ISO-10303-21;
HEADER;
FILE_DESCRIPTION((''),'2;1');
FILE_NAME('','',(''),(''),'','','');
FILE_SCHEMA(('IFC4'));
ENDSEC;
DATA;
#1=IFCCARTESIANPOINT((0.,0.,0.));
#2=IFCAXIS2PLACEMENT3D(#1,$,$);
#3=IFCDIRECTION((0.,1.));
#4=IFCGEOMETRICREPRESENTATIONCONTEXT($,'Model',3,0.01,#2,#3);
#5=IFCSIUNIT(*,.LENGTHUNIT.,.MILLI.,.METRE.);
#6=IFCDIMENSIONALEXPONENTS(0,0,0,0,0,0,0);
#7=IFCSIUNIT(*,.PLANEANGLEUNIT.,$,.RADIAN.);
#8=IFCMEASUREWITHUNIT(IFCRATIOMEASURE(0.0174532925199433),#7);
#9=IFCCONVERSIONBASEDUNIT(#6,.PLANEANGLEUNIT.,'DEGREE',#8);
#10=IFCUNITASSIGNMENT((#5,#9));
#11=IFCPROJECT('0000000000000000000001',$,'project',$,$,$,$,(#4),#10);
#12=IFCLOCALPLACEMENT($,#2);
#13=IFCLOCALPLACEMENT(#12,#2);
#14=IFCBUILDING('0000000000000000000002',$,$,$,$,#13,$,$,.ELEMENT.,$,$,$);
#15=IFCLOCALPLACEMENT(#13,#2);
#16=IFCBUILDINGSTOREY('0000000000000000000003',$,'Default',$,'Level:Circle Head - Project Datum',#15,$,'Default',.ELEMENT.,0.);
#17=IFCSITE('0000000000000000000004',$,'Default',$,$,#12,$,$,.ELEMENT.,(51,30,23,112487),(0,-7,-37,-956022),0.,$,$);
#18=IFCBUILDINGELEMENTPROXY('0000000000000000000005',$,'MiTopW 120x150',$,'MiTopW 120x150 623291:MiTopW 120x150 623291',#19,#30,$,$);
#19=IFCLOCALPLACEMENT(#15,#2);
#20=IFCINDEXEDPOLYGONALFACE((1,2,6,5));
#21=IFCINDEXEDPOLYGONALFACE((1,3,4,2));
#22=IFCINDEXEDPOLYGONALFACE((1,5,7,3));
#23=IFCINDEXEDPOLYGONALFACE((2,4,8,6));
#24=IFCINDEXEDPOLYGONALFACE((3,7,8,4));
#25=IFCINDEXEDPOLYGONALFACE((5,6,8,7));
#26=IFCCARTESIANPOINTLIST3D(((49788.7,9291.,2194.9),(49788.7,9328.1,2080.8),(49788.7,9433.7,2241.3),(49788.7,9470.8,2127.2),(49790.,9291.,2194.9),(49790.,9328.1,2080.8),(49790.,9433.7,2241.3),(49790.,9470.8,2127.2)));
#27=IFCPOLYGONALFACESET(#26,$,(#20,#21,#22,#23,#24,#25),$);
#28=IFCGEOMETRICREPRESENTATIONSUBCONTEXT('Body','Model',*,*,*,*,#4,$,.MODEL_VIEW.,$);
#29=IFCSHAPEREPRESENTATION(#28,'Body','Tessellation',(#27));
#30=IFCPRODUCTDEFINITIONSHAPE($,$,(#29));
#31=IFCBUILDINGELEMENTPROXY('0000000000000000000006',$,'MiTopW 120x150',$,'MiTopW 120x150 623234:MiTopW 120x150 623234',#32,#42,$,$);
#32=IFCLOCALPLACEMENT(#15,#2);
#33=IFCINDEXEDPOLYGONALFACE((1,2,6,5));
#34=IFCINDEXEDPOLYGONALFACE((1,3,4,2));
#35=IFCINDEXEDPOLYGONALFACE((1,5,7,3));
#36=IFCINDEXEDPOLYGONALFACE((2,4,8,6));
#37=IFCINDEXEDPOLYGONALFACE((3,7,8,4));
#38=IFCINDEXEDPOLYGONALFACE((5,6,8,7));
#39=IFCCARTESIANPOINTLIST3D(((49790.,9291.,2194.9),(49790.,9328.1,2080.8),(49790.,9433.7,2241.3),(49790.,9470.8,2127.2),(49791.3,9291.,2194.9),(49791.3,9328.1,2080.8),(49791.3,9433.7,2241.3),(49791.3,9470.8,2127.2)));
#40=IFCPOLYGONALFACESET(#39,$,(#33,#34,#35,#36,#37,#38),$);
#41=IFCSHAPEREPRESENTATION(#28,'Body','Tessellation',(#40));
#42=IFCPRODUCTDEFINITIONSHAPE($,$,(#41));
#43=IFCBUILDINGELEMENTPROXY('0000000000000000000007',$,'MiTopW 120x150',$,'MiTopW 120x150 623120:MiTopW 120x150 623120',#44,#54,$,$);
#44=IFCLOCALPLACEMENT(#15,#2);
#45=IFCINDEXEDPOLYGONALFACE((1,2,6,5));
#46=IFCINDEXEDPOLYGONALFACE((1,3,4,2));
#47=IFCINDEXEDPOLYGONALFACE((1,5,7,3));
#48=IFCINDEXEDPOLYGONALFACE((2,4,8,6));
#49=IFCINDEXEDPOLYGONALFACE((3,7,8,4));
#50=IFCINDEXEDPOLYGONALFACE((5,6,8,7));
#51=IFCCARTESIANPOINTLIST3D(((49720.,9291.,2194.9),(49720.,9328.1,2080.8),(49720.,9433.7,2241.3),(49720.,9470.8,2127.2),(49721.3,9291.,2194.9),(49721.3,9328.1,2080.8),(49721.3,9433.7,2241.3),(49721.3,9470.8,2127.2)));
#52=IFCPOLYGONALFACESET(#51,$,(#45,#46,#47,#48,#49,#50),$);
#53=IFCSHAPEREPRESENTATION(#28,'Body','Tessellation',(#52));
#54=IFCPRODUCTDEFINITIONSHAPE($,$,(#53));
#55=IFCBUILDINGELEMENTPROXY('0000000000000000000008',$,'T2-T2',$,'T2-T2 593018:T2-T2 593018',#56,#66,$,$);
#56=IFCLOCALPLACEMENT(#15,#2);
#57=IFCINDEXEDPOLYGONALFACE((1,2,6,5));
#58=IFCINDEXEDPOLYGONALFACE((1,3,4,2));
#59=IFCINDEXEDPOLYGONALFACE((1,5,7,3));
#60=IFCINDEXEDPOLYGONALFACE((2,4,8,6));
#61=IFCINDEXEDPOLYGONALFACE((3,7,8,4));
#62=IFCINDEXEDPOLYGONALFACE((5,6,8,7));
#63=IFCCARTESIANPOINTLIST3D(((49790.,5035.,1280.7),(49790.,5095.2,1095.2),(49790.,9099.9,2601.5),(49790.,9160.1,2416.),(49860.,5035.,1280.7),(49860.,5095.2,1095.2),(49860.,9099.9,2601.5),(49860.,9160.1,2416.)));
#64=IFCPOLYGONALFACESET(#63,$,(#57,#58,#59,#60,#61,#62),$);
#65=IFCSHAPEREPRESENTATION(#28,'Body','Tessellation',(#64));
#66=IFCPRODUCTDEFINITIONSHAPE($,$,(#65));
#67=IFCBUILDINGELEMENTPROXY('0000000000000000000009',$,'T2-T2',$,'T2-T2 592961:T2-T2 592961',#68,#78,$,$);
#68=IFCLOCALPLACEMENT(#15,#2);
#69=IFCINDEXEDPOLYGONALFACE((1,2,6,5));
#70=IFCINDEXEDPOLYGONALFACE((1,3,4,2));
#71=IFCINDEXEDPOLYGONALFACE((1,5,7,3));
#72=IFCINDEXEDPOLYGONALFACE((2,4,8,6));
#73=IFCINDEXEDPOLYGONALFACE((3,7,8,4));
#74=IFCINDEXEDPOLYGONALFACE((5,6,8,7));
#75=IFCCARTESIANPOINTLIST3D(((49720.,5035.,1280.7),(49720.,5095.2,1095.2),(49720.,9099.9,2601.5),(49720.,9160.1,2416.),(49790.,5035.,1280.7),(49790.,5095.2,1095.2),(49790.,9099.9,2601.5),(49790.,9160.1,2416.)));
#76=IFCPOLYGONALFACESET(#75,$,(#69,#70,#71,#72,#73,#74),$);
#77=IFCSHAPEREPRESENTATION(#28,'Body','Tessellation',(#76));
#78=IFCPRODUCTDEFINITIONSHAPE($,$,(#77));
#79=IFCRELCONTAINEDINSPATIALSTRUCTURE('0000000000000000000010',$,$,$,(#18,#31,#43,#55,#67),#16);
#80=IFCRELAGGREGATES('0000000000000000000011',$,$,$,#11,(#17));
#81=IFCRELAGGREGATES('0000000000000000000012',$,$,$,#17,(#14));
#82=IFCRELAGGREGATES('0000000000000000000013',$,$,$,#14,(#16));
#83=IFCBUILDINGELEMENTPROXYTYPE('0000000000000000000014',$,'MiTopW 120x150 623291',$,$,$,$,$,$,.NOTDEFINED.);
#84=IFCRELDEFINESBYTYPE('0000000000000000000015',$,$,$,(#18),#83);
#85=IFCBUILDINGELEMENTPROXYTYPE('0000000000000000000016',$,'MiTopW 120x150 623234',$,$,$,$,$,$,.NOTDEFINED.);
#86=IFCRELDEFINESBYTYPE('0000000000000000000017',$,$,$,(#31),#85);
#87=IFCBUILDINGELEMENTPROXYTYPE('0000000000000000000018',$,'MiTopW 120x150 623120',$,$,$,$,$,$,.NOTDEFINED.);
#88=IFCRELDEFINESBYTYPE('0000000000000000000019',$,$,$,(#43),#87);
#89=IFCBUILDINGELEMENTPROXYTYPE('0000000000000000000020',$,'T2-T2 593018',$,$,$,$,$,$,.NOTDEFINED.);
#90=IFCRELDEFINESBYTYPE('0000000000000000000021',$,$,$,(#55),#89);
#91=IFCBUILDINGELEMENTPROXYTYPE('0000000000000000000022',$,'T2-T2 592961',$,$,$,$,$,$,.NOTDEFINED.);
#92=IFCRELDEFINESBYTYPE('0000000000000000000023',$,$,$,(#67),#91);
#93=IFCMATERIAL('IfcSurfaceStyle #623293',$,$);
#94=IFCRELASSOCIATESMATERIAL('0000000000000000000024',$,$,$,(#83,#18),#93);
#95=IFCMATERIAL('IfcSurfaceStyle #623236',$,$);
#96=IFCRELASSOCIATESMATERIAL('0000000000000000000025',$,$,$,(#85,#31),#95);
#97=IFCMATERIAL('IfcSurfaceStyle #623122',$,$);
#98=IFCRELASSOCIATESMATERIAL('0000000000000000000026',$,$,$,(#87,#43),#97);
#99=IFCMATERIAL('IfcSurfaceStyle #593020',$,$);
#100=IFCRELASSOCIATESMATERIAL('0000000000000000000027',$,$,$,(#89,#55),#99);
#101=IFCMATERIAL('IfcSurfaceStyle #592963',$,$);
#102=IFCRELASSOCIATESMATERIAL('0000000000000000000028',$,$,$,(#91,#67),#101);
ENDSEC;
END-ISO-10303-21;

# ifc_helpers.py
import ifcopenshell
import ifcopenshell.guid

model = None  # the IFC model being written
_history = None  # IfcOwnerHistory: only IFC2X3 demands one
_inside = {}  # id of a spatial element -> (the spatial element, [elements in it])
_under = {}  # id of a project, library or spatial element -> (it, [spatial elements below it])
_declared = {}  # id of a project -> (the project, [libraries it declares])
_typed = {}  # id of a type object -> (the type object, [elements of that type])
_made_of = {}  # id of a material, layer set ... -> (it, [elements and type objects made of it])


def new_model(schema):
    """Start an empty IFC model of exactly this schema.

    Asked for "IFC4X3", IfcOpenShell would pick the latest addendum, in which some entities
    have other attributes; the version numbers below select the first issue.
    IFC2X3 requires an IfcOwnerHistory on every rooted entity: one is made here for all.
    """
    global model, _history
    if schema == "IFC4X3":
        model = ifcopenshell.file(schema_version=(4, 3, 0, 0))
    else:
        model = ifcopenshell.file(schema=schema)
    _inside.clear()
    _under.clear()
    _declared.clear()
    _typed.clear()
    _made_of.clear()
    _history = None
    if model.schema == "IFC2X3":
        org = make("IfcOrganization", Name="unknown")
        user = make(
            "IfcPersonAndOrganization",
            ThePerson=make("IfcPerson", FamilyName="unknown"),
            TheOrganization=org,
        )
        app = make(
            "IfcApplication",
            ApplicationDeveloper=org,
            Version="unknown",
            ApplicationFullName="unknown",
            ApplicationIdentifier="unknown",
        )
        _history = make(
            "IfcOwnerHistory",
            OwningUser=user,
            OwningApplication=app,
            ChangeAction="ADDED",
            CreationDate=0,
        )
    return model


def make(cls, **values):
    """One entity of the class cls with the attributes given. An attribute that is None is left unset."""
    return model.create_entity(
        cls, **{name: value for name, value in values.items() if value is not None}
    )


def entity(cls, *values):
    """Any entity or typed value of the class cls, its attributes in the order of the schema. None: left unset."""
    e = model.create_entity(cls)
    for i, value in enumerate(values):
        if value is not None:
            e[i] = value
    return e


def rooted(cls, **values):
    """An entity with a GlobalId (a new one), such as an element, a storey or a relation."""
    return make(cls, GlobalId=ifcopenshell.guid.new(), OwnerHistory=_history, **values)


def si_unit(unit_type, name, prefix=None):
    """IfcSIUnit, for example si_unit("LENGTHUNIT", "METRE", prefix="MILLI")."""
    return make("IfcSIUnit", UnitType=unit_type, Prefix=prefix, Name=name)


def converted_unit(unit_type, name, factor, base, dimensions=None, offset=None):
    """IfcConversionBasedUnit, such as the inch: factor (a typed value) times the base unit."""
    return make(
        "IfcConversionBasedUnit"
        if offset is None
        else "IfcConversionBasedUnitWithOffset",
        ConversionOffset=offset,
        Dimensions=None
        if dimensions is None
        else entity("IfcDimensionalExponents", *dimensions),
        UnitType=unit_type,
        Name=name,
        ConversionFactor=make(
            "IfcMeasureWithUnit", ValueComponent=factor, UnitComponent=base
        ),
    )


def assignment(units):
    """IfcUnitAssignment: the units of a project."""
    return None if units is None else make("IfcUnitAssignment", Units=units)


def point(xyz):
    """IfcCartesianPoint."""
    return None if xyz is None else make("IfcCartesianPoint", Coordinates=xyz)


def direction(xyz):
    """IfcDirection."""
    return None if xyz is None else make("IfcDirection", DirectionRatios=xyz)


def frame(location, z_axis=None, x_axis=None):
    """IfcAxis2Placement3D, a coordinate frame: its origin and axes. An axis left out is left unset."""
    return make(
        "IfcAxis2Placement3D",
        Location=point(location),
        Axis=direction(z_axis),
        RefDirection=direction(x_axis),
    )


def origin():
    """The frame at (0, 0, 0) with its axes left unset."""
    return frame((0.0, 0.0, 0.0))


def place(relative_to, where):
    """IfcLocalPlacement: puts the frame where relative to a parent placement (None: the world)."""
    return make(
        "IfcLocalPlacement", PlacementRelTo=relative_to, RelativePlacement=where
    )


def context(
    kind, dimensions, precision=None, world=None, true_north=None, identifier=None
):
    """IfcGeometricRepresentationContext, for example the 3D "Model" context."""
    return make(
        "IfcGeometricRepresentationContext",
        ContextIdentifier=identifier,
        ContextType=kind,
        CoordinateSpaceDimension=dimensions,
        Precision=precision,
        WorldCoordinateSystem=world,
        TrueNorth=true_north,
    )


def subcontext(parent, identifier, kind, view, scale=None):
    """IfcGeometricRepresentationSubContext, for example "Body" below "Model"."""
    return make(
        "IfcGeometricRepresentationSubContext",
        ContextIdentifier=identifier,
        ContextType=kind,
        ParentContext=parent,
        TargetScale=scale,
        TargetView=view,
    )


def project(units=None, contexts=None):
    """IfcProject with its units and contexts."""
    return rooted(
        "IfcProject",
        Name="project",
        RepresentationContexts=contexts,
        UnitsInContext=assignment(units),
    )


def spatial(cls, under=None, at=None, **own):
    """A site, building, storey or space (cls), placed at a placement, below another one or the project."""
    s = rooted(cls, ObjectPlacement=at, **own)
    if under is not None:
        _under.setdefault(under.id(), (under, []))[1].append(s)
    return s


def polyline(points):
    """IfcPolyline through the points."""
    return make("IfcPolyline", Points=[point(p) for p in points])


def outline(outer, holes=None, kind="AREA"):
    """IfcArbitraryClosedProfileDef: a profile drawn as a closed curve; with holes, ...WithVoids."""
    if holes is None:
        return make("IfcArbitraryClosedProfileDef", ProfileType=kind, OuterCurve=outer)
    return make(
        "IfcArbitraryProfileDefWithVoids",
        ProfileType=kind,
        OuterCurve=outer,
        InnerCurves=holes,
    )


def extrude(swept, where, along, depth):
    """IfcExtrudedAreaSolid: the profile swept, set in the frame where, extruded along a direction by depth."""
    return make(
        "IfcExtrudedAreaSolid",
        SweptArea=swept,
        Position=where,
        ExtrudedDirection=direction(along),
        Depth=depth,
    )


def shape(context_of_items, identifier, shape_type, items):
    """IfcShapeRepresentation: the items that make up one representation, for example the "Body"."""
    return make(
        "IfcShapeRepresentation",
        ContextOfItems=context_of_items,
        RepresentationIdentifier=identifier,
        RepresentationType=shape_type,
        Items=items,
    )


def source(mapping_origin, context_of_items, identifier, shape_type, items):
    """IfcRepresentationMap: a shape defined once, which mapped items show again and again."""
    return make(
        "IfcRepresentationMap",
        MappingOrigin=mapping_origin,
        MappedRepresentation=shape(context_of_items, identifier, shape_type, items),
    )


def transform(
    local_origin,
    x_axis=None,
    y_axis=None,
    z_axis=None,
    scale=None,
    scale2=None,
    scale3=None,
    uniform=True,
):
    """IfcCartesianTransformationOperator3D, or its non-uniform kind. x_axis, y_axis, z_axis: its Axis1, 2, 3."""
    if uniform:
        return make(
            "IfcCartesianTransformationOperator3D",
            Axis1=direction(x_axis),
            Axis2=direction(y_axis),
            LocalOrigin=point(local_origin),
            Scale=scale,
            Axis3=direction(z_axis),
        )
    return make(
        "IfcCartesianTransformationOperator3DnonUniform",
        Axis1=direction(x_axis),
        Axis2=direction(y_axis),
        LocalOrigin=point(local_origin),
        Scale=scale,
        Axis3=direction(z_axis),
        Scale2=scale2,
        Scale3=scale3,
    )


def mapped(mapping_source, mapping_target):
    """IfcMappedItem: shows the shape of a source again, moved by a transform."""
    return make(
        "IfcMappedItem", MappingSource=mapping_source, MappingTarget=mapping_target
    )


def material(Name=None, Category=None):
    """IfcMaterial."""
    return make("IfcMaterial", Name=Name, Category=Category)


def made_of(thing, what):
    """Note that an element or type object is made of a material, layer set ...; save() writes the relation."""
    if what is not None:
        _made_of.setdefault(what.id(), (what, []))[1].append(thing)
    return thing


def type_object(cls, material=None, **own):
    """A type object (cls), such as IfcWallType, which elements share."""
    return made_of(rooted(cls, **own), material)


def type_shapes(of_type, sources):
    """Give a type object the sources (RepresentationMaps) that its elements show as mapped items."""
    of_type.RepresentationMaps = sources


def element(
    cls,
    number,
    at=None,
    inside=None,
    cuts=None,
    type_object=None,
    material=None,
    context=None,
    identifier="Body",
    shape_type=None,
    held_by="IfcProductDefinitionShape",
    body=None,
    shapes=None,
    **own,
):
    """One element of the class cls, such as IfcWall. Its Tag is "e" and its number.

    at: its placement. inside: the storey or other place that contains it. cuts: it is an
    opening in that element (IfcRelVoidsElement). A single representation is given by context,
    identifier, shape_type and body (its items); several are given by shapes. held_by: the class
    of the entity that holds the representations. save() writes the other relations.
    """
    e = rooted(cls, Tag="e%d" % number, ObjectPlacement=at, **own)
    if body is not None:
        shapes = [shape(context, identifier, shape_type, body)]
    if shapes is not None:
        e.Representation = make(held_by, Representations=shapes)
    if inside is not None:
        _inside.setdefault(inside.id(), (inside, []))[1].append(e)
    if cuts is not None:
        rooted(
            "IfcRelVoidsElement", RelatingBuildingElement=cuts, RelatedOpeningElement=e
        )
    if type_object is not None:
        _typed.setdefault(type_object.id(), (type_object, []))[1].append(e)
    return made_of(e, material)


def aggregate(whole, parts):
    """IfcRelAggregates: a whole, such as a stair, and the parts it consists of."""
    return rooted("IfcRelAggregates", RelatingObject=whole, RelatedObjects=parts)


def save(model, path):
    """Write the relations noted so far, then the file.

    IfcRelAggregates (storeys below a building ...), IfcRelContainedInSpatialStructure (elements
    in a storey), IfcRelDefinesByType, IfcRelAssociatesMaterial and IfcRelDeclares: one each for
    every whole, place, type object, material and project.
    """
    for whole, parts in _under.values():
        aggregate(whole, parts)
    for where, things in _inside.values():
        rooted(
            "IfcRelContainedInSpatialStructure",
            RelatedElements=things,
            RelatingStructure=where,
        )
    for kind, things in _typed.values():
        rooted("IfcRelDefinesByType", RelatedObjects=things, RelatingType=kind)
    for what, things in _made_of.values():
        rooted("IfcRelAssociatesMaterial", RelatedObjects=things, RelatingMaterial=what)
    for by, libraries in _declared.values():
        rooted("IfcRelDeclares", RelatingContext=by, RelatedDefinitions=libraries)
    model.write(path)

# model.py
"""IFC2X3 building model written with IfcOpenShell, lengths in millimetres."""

from ifc_helpers import new_model, entity, si_unit, converted_unit, direction, frame, origin, place, context, subcontext, project, spatial, polyline, outline, extrude, source, transform, mapped, material, type_object, type_shapes, element, save


model = new_model("IFC2X3")

# Units and contexts
model_context = context("Model", 3, precision=0.01, world=origin(), true_north=direction((0.0, 1.0)))
body_context = subcontext(model_context, "Body", "Model", "MODEL_VIEW")
ifc_project = project(units=[si_unit("LENGTHUNIT", "METRE", prefix="MILLI"), converted_unit("PLANEANGLEUNIT", "DEGREE", entity("IfcRatioMeasure", 0.0174532925199433), si_unit("PLANEANGLEUNIT", "RADIAN"), dimensions=[0, 0, 0, 0, 0, 0, 0])], contexts=[model_context])

# Site, building, storey
site_placement = place(None, origin())
site = spatial("IfcSite", under=ifc_project, at=site_placement, Name="Default", CompositionType="ELEMENT", RefLatitude=(51, 30, 23, 112487), RefLongitude=(0, -7, -37, -956022), RefElevation=0.0)
building_placement = place(site_placement, origin())
building = spatial("IfcBuilding", under=site, at=building_placement, CompositionType="ELEMENT")
storey_placement = place(building_placement, origin())
storey = spatial("IfcBuildingStorey", under=building, at=storey_placement, Name="Default", ObjectType="Level:Circle Head - Project Datum", LongName="Default", CompositionType="ELEMENT", Elevation=0.0)

# Building element proxies
ifc_material_1 = material(Name="IfcSurfaceStyle #623293")
building_element_proxy_type_1 = type_object("IfcBuildingElementProxyType", Name="MiTopW 120x150 623291", PredefinedType="NOTDEFINED", material=ifc_material_1)
shared_shape_1 = source(origin(), body_context, "Body", "SweptSolid", [
    extrude(outline(polyline([(-75.0, -60.0), (75.0, -60.0), (75.0, 60.0), (-75.0, 60.0), (-75.0, -60.0)])), frame((75.0, 60.0, 0.0), z_axis=(0.0, 0.0, 1.0), x_axis=(-1.0, 0.0, 0.0)), (0.0, 0.0, 1.0), 1.3),
])
type_shapes(building_element_proxy_type_1, [shared_shape_1])
proxy_1_placement = place(building_placement, frame((49790.0, 9291.0, 2194.9), z_axis=(-1.0, 0.0, 0.0), x_axis=(0.0, 0.951057, 0.309017)))
element("IfcBuildingElementProxy", 1, at=proxy_1_placement, inside=storey, type_object=building_element_proxy_type_1, material=ifc_material_1, Name="MiTopW 120x150", ObjectType="MiTopW 120x150 623291:MiTopW 120x150 623291", context=body_context, shape_type="MappedRepresentation", body=[
    mapped(shared_shape_1, transform((0.0, 0.0, 0.0), scale=1.0)),
])
ifc_material_2 = material(Name="IfcSurfaceStyle #623236")
building_element_proxy_type_2 = type_object("IfcBuildingElementProxyType", Name="MiTopW 120x150 623234", PredefinedType="NOTDEFINED", material=ifc_material_2)
shared_shape_2 = source(origin(), body_context, "Body", "SweptSolid", [
    extrude(outline(polyline([(-75.0, -60.0), (75.0, -60.0), (75.0, 60.0), (-75.0, 60.0), (-75.0, -60.0)])), frame((75.0, 60.0, 0.0), z_axis=(0.0, 0.0, 1.0), x_axis=(-1.0, 0.0, 0.0)), (0.0, 0.0, 1.0), 1.3),
])
type_shapes(building_element_proxy_type_2, [shared_shape_2])
proxy_2_placement = place(building_placement, frame((49791.3, 9291.0, 2194.9), z_axis=(-1.0, 0.0, 0.0), x_axis=(0.0, 0.951057, 0.309017)))
element("IfcBuildingElementProxy", 2, at=proxy_2_placement, inside=storey, type_object=building_element_proxy_type_2, material=ifc_material_2, Name="MiTopW 120x150", ObjectType="MiTopW 120x150 623234:MiTopW 120x150 623234", context=body_context, shape_type="MappedRepresentation", body=[
    mapped(shared_shape_2, transform((0.0, 0.0, 0.0), scale=1.0)),
])
ifc_material_3 = material(Name="IfcSurfaceStyle #623122")
building_element_proxy_type_3 = type_object("IfcBuildingElementProxyType", Name="MiTopW 120x150 623120", PredefinedType="NOTDEFINED", material=ifc_material_3)
shared_shape_3 = source(origin(), body_context, "Body", "SweptSolid", [
    extrude(outline(polyline([(-75.0, -60.0), (75.0, -60.0), (75.0, 60.0), (-75.0, 60.0), (-75.0, -60.0)])), frame((75.0, 60.0, 0.0), z_axis=(0.0, 0.0, 1.0), x_axis=(-1.0, 0.0, 0.0)), (0.0, 0.0, 1.0), 1.3),
])
type_shapes(building_element_proxy_type_3, [shared_shape_3])
proxy_3_placement = place(building_placement, frame((49721.3, 9291.0, 2194.9), z_axis=(-1.0, 0.0, 0.0), x_axis=(0.0, 0.951057, 0.309017)))
element("IfcBuildingElementProxy", 3, at=proxy_3_placement, inside=storey, type_object=building_element_proxy_type_3, material=ifc_material_3, Name="MiTopW 120x150", ObjectType="MiTopW 120x150 623120:MiTopW 120x150 623120", context=body_context, shape_type="MappedRepresentation", body=[
    mapped(shared_shape_3, transform((0.0, 0.0, 0.0), scale=1.0)),
])
ifc_material_4 = material(Name="IfcSurfaceStyle #593020")
building_element_proxy_type_4 = type_object("IfcBuildingElementProxyType", Name="T2-T2 593018", PredefinedType="NOTDEFINED", material=ifc_material_4)
shared_shape_4 = source(origin(), body_context, "Body", "SweptSolid", [
    extrude(outline(polyline([(-2137.0, -97.5), (2137.0, -97.5), (2137.0, 97.5), (-2137.0, 97.5), (-2137.0, -97.5)])), frame((2137.0, 97.5, 0.0), z_axis=(0.0, 0.0, 1.0), x_axis=(-1.0, 0.0, 0.0)), (0.0, 0.0, 1.0), 70.0),
])
type_shapes(building_element_proxy_type_4, [shared_shape_4])
proxy_4_placement = place(building_placement, frame((49860.0, 9160.1, 2416.0), z_axis=(-1.0, 0.0, 0.0), x_axis=(0.0, -0.951057, -0.309017)))
element("IfcBuildingElementProxy", 4, at=proxy_4_placement, inside=storey, type_object=building_element_proxy_type_4, material=ifc_material_4, Name="T2-T2", ObjectType="T2-T2 593018:T2-T2 593018", context=body_context, shape_type="MappedRepresentation", body=[
    mapped(shared_shape_4, transform((0.0, 0.0, 0.0), scale=1.0)),
])
ifc_material_5 = material(Name="IfcSurfaceStyle #592963")
building_element_proxy_type_5 = type_object("IfcBuildingElementProxyType", Name="T2-T2 592961", PredefinedType="NOTDEFINED", material=ifc_material_5)
shared_shape_5 = source(origin(), body_context, "Body", "SweptSolid", [
    extrude(outline(polyline([(-2137.0, -97.5), (2137.0, -97.5), (2137.0, 97.5), (-2137.0, 97.5), (-2137.0, -97.5)])), frame((2137.0, 97.5, 0.0), z_axis=(0.0, 0.0, 1.0), x_axis=(-1.0, 0.0, 0.0)), (0.0, 0.0, 1.0), 70.0),
])
type_shapes(building_element_proxy_type_5, [shared_shape_5])
proxy_5_placement = place(building_placement, frame((49790.0, 9160.1, 2416.0), z_axis=(-1.0, 0.0, 0.0), x_axis=(0.0, -0.951057, -0.309017)))
element("IfcBuildingElementProxy", 5, at=proxy_5_placement, inside=storey, type_object=building_element_proxy_type_5, material=ifc_material_5, Name="T2-T2", ObjectType="T2-T2 592961:T2-T2 592961", context=body_context, shape_type="MappedRepresentation", body=[
    mapped(shared_shape_5, transform((0.0, 0.0, 0.0), scale=1.0)),
])

save(model, "model.ifc")
